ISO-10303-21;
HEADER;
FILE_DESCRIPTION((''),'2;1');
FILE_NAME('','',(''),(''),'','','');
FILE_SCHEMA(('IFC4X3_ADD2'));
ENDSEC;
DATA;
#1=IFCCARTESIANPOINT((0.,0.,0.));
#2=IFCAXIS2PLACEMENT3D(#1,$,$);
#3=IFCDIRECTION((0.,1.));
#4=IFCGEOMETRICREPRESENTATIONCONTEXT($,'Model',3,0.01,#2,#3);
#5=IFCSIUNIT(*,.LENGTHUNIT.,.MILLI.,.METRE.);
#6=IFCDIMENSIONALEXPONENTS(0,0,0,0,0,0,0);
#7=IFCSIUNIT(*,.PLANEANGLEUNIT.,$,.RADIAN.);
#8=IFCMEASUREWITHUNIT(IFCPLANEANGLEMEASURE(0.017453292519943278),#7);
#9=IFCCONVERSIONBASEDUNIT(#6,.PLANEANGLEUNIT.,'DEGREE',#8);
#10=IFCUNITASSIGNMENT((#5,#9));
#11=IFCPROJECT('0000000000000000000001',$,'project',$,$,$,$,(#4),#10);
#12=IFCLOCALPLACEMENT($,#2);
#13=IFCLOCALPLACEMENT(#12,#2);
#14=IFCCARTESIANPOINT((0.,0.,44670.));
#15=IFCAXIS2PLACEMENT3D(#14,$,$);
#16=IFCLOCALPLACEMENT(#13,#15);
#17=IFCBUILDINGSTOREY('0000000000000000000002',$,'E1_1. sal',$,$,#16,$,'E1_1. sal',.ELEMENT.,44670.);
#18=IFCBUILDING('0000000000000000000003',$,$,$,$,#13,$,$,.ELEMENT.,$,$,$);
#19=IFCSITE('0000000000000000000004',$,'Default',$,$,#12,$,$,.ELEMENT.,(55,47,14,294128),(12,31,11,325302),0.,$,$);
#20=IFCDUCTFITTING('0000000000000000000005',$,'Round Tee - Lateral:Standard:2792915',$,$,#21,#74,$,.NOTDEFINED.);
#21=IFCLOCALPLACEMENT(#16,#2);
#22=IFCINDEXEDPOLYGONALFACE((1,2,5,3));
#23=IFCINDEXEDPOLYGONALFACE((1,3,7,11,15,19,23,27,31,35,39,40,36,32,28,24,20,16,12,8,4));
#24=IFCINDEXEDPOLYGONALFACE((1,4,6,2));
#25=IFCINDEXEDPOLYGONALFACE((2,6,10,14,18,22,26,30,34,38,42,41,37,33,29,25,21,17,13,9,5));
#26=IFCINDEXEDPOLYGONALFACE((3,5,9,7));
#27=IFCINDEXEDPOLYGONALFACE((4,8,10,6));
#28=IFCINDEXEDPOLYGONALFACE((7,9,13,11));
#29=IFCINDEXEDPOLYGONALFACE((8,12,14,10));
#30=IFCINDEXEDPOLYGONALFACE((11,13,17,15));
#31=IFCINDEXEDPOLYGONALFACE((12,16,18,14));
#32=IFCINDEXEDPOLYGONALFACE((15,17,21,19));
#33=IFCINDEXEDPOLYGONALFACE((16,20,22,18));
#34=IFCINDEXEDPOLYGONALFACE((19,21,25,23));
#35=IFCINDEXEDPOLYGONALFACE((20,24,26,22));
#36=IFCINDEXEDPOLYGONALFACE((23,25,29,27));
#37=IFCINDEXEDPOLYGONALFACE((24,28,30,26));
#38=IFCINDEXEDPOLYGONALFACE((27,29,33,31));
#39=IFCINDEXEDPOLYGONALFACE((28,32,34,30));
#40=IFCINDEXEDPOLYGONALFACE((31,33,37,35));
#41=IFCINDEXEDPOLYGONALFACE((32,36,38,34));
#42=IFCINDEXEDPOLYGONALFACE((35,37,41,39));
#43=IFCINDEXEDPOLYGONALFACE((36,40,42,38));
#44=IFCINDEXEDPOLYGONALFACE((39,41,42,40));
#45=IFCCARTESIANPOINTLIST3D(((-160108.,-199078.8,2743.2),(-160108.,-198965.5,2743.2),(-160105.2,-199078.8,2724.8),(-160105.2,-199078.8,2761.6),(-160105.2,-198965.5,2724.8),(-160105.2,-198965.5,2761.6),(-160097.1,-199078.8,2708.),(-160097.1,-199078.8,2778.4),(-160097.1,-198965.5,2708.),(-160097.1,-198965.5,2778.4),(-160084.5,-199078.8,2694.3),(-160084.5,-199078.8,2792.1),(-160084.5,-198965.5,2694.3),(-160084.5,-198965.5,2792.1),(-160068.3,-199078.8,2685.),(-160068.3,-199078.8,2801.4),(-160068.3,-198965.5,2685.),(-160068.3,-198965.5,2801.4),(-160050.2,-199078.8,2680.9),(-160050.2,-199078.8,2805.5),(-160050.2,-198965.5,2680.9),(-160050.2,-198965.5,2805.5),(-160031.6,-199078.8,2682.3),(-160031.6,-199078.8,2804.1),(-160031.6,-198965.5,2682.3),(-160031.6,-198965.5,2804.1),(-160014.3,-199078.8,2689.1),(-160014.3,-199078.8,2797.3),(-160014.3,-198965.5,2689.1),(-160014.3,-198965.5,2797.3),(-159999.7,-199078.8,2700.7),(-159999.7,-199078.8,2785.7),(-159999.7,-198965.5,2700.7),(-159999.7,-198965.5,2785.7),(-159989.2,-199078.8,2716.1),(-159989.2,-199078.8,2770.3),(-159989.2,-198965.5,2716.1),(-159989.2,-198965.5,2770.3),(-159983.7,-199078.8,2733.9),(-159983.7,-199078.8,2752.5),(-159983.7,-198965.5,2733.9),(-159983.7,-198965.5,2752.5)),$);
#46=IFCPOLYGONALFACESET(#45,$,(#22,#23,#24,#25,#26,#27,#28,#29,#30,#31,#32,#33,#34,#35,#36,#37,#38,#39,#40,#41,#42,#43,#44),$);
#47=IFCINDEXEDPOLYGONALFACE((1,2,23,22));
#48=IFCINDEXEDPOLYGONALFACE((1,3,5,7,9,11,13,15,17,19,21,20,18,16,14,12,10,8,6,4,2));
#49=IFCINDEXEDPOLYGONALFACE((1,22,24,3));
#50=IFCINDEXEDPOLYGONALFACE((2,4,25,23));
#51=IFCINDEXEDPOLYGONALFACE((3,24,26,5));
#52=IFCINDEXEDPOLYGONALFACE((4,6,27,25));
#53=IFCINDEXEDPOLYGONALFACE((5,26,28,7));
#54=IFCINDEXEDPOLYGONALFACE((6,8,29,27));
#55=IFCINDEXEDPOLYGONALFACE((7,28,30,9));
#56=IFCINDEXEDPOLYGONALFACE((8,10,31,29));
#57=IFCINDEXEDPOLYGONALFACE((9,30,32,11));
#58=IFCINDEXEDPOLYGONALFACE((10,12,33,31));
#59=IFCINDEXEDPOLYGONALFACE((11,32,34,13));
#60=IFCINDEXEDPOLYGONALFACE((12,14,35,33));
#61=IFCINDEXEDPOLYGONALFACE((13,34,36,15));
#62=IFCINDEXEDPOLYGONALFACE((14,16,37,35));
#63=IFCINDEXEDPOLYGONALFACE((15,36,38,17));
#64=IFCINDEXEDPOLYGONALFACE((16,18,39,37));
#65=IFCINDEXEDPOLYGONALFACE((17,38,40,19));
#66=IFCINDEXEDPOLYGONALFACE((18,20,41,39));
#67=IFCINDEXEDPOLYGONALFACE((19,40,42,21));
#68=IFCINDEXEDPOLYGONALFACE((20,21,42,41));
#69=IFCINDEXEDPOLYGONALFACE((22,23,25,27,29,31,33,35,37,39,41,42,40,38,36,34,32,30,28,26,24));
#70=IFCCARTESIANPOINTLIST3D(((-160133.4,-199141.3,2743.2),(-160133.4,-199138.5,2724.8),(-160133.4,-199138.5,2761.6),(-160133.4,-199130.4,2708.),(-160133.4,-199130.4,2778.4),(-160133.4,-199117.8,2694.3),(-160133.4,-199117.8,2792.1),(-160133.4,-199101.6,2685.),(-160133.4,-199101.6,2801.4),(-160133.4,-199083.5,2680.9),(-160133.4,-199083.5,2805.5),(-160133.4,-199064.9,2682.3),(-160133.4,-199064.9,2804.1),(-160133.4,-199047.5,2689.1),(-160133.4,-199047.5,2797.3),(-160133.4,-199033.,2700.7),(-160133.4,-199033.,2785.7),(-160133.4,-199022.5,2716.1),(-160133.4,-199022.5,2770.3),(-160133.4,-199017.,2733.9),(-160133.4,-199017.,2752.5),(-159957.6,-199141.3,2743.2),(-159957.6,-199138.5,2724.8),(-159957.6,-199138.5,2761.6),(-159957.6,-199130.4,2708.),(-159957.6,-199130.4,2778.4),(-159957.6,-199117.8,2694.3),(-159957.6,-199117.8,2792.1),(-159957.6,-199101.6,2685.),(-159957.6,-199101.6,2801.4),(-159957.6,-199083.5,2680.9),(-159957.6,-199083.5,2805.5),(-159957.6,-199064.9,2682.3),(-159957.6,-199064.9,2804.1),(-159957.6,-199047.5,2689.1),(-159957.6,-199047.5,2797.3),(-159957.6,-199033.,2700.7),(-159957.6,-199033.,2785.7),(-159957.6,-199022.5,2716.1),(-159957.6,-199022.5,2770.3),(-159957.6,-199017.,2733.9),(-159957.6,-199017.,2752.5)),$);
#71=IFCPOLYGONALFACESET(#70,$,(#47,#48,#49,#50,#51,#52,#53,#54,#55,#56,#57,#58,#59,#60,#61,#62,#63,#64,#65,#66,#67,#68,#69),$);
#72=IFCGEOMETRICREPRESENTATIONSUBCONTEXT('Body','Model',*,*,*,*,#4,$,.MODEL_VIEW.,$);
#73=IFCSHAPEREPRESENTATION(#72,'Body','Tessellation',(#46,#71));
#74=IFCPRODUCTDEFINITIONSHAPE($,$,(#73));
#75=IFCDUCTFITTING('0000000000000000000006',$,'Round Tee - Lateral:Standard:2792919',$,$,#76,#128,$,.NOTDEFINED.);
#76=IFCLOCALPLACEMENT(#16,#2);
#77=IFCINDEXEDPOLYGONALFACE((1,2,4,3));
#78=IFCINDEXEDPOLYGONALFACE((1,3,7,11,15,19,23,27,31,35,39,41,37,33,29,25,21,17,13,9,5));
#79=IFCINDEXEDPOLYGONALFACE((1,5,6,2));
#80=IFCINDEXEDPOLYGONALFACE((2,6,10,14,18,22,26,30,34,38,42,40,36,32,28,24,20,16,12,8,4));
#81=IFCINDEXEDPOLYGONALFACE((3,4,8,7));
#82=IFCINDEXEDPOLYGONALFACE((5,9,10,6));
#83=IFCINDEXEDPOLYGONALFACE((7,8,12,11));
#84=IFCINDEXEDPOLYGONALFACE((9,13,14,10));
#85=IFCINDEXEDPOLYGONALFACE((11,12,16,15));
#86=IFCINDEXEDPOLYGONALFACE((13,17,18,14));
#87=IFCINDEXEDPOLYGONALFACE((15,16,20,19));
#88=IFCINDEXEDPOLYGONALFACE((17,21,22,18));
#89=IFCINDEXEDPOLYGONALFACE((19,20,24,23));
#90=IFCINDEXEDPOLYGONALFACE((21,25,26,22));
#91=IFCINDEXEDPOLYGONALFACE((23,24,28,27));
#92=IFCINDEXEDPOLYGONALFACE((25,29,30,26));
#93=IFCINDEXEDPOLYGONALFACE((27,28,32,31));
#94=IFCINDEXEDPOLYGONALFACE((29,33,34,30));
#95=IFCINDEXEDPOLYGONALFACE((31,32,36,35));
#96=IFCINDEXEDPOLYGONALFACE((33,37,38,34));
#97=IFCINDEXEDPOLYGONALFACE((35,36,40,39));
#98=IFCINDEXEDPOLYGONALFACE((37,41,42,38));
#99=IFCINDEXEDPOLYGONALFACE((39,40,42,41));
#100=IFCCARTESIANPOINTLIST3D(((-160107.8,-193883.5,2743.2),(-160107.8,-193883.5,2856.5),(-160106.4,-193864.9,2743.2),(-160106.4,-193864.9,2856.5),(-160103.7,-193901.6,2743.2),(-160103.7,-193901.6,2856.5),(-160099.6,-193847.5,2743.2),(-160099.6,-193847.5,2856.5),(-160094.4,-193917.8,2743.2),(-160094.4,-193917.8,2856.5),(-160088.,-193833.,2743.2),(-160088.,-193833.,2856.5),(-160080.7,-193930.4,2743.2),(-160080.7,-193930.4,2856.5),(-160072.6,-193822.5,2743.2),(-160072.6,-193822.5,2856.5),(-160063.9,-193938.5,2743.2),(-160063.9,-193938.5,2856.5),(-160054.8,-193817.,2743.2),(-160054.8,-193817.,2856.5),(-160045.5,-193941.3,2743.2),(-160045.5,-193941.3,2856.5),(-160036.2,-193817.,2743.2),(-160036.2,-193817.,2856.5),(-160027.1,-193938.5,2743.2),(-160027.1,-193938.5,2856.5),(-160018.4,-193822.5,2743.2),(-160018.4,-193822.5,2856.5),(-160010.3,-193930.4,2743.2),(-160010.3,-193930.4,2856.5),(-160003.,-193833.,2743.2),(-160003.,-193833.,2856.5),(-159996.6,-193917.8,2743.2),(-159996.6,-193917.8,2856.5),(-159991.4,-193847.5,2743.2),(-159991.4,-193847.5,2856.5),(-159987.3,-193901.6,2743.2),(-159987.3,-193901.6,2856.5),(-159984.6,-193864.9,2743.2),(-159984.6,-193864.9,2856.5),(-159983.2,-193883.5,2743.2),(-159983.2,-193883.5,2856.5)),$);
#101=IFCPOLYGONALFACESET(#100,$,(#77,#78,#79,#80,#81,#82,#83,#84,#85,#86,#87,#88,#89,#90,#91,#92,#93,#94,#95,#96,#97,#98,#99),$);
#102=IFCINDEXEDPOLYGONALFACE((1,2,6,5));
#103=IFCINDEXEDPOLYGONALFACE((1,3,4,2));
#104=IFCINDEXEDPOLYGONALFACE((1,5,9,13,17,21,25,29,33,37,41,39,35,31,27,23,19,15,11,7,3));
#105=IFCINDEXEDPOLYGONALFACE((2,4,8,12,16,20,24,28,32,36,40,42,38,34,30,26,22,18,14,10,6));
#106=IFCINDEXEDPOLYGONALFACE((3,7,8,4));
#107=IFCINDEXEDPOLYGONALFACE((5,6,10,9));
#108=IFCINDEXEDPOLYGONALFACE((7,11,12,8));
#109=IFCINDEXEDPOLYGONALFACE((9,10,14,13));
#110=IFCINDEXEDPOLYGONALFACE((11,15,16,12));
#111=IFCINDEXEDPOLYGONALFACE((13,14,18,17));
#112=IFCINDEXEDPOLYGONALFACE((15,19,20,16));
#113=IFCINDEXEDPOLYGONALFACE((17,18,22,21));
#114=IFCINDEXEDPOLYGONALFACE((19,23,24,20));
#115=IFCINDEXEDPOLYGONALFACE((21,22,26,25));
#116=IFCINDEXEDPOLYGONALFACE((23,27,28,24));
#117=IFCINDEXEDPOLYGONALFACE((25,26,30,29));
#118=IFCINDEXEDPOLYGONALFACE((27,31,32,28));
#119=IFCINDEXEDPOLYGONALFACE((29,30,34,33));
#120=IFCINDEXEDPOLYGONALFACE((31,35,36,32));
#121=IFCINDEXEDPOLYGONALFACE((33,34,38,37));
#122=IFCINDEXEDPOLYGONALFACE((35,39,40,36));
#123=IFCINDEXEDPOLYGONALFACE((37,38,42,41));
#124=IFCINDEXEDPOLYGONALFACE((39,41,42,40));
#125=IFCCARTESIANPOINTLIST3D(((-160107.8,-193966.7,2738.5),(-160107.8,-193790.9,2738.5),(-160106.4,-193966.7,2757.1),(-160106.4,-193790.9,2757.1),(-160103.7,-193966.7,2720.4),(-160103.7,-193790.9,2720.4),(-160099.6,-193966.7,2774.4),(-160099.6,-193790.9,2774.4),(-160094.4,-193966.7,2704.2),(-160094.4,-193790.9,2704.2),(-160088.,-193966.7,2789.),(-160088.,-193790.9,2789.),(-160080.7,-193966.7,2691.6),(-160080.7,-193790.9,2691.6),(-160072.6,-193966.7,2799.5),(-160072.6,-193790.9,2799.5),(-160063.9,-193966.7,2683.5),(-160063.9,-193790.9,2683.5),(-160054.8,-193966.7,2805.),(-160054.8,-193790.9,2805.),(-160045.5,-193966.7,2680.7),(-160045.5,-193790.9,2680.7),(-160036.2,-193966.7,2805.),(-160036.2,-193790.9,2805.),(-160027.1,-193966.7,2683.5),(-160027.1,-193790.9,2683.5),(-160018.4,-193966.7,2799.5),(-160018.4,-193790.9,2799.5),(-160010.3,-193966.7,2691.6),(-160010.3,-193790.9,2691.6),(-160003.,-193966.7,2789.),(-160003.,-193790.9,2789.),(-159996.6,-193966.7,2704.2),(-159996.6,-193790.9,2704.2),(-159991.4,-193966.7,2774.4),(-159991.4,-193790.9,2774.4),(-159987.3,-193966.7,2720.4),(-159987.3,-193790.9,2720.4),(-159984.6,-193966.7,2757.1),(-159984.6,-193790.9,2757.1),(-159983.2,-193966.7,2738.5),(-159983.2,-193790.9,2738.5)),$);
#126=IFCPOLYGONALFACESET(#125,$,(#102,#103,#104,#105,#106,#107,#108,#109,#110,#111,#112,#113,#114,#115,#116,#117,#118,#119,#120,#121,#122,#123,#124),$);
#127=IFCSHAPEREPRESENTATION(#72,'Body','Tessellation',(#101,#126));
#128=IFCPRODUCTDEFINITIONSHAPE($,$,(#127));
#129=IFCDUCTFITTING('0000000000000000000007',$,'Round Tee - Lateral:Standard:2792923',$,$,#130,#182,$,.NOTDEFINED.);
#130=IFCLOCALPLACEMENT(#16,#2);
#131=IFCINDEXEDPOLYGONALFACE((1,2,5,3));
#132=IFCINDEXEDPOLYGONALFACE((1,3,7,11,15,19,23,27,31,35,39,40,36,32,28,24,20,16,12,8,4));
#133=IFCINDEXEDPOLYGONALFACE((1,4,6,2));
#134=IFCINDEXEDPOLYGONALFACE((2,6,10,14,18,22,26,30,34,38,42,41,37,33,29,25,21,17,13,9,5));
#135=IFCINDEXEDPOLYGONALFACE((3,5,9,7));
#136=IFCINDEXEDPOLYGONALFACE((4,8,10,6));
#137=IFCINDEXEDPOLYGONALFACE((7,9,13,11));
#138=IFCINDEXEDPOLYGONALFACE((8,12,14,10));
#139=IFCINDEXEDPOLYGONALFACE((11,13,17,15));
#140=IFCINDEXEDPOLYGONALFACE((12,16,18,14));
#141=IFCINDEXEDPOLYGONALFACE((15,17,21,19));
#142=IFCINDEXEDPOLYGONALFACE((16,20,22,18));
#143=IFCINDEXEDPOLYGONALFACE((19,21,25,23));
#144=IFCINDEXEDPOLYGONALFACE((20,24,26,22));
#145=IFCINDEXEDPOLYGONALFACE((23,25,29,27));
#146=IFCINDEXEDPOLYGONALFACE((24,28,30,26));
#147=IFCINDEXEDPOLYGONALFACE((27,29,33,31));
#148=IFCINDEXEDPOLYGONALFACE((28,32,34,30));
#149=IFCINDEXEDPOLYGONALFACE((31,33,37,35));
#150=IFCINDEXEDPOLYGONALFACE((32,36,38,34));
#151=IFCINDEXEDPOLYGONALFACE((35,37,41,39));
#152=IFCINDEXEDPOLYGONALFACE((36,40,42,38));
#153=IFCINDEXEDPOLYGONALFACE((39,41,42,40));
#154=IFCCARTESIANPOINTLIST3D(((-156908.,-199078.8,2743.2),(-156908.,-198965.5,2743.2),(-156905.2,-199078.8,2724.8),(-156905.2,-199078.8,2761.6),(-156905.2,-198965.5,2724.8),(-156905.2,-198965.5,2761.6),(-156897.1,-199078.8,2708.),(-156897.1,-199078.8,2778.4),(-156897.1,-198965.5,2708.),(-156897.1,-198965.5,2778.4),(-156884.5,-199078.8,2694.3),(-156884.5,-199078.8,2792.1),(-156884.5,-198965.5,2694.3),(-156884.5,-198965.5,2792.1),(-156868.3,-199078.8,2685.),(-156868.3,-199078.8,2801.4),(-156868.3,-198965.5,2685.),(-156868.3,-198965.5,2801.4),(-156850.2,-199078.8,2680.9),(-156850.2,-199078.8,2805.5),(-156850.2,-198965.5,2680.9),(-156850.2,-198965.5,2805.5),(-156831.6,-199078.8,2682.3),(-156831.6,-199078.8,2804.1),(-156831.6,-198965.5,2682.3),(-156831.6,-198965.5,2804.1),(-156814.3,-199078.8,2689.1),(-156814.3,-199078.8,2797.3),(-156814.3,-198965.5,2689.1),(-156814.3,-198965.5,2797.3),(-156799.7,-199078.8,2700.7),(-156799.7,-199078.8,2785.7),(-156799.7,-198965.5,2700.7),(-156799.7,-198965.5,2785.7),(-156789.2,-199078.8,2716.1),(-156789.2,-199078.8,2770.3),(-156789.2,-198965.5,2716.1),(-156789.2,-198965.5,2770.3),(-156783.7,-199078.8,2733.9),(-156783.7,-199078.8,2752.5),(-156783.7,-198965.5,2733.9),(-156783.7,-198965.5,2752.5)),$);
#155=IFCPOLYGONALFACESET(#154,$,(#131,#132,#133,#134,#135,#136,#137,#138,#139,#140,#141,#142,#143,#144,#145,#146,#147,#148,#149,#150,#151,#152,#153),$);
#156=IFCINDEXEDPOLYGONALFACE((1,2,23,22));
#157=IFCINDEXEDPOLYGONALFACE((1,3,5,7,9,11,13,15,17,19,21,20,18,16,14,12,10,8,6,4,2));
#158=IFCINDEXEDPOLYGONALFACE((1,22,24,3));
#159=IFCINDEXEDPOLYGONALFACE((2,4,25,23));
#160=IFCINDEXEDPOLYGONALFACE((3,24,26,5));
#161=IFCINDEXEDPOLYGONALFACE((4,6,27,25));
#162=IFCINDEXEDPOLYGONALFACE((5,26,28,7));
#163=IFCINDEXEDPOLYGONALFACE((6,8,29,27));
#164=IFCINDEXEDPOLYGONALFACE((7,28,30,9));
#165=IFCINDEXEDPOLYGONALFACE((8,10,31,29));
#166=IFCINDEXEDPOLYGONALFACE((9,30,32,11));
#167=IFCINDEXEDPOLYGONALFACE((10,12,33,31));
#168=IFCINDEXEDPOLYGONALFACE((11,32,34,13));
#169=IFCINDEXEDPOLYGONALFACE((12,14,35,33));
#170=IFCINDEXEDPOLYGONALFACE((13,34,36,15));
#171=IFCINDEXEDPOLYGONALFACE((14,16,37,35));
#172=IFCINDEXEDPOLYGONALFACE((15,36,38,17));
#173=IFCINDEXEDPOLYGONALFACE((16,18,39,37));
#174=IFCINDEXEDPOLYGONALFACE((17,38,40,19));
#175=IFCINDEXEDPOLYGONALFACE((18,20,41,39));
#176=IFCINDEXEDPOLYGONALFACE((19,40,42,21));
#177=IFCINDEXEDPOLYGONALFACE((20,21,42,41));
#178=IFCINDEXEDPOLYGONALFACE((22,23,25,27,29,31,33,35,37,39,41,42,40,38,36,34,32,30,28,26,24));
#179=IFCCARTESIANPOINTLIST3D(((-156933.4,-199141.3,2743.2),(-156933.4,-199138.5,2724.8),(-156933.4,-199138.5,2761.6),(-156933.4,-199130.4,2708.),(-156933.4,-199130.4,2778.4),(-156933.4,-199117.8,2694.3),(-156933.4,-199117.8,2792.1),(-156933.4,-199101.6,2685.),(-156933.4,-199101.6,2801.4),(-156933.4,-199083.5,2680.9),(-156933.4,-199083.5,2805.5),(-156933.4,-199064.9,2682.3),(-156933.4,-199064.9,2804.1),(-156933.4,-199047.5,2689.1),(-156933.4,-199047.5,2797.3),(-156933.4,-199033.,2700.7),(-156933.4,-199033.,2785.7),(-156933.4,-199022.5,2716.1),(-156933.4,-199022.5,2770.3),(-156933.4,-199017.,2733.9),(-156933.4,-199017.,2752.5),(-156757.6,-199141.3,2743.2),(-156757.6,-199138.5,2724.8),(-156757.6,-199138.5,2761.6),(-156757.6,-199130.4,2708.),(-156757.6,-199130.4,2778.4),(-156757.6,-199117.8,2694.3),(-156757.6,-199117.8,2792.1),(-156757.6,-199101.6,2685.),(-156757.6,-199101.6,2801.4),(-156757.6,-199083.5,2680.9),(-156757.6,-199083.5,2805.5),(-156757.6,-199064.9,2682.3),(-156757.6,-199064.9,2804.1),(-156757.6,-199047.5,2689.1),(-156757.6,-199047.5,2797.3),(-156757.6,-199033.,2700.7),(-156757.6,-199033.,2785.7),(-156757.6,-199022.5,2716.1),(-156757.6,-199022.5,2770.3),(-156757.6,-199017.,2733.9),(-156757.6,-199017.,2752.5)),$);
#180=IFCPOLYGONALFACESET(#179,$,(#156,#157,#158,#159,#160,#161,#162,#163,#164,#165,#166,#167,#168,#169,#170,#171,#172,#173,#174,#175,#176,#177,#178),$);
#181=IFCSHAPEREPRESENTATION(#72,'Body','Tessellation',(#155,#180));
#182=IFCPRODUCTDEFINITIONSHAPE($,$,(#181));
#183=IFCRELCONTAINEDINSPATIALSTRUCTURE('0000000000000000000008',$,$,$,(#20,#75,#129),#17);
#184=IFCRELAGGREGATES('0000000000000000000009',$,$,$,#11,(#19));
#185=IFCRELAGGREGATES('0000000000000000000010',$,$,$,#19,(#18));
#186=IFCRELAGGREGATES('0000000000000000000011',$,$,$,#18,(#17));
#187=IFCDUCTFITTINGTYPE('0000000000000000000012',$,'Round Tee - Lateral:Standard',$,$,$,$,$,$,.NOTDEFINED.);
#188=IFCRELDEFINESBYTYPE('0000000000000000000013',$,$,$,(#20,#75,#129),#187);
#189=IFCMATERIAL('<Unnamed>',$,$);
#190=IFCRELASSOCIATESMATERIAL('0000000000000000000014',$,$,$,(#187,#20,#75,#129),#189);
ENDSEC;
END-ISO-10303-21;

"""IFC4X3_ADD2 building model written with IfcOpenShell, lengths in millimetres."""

from ifc_helpers import new_model, entity, si_unit, converted_unit, direction, frame, frame_2d, origin, place, context, subcontext, project, spatial, circle, extrude, source, transform, mapped, material, type_object, type_shapes, element, save


model = new_model("IFC4X3_ADD2")

# Units and contexts
model_context = context("Model", 3, precision=0.01, world=origin(), true_north=direction((0.0, 1.0)))
body_context = subcontext(model_context, "Body", "Model", "MODEL_VIEW")
ifc_project = project(units=[si_unit("LENGTHUNIT", "METRE", prefix="MILLI"), converted_unit("PLANEANGLEUNIT", "DEGREE", entity("IfcPlaneAngleMeasure", 0.017453292519943278), si_unit("PLANEANGLEUNIT", "RADIAN"), dimensions=[0, 0, 0, 0, 0, 0, 0])], contexts=[model_context])

# Site, building, storey
site_placement = place(None, origin())
site = spatial("IfcSite", under=ifc_project, at=site_placement, Name="Default", CompositionType="ELEMENT", RefLatitude=(55, 47, 14, 294128), RefLongitude=(12, 31, 11, 325302), RefElevation=0.0)
building_placement = place(site_placement, origin())
building = spatial("IfcBuilding", under=site, at=building_placement, CompositionType="ELEMENT")
storey_placement = place(building_placement, frame((0.0, 0.0, 44670.0)))
storey = spatial("IfcBuildingStorey", under=building, at=storey_placement, Name="E1_1. sal", LongName="E1_1. sal", CompositionType="ELEMENT", Elevation=44670.0)

# Shared definitions
ifc_material_1 = material(Name="<Unnamed>")

# Duct fittings
duct_fitting_type = type_object("IfcDuctFittingType", Name="Round Tee - Lateral:Standard", PredefinedType="NOTDEFINED", material=ifc_material_1)
shared_shape_1 = source(origin(), body_context, "Body", "SweptSolid", [
    extrude(circle(Radius=62.5, at=frame_2d((0.0, 0.0), x_axis=(1.0, 0.0))), frame((0.0, -113.3, 0.0), z_axis=(0.0, 1.0, 0.0), x_axis=(1.0, 0.0, 0.0)), (0.0, 0.0, 1.0), 113.3),
    extrude(circle(Radius=62.5, at=frame_2d((0.0, 0.0), x_axis=(1.0, 0.0))), frame((-87.9, 0.0, 0.0), z_axis=(1.0, 0.0, 0.0), x_axis=(0.0, 1.0, 0.0)), (0.0, 0.0, 1.0), 175.8),
])
type_shapes(duct_fitting_type, [shared_shape_1])
for number, where, z_axis, x_axis, name in (
    (1, (-160045.5, -199078.8, 2743.2), (0.0, 0.0, 1.0), (-1.0, 0.0, 0.0), "Round Tee - Lateral:Standard:2792915"),
    (2, (-160045.5, -193878.8, 2743.2), (1.0, 0.0, 0.0), (0.0, -1.0, 0.0), "Round Tee - Lateral:Standard:2792919"),
    (3, (-156845.5, -199078.8, 2743.2), (0.0, 0.0, 1.0), (-1.0, 0.0, 0.0), "Round Tee - Lateral:Standard:2792923"),
):
    element("IfcDuctFitting", number, at=place(storey_placement, frame(where, z_axis=z_axis, x_axis=x_axis)), inside=storey, type_object=duct_fitting_type, material=ifc_material_1, Name=name, PredefinedType="NOTDEFINED", context=body_context, shape_type="MappedRepresentation", body=[
        mapped(shared_shape_1, transform((0.0, 0.0, 0.0), scale=1.0)),
    ])

save(model, "model.ifc")
